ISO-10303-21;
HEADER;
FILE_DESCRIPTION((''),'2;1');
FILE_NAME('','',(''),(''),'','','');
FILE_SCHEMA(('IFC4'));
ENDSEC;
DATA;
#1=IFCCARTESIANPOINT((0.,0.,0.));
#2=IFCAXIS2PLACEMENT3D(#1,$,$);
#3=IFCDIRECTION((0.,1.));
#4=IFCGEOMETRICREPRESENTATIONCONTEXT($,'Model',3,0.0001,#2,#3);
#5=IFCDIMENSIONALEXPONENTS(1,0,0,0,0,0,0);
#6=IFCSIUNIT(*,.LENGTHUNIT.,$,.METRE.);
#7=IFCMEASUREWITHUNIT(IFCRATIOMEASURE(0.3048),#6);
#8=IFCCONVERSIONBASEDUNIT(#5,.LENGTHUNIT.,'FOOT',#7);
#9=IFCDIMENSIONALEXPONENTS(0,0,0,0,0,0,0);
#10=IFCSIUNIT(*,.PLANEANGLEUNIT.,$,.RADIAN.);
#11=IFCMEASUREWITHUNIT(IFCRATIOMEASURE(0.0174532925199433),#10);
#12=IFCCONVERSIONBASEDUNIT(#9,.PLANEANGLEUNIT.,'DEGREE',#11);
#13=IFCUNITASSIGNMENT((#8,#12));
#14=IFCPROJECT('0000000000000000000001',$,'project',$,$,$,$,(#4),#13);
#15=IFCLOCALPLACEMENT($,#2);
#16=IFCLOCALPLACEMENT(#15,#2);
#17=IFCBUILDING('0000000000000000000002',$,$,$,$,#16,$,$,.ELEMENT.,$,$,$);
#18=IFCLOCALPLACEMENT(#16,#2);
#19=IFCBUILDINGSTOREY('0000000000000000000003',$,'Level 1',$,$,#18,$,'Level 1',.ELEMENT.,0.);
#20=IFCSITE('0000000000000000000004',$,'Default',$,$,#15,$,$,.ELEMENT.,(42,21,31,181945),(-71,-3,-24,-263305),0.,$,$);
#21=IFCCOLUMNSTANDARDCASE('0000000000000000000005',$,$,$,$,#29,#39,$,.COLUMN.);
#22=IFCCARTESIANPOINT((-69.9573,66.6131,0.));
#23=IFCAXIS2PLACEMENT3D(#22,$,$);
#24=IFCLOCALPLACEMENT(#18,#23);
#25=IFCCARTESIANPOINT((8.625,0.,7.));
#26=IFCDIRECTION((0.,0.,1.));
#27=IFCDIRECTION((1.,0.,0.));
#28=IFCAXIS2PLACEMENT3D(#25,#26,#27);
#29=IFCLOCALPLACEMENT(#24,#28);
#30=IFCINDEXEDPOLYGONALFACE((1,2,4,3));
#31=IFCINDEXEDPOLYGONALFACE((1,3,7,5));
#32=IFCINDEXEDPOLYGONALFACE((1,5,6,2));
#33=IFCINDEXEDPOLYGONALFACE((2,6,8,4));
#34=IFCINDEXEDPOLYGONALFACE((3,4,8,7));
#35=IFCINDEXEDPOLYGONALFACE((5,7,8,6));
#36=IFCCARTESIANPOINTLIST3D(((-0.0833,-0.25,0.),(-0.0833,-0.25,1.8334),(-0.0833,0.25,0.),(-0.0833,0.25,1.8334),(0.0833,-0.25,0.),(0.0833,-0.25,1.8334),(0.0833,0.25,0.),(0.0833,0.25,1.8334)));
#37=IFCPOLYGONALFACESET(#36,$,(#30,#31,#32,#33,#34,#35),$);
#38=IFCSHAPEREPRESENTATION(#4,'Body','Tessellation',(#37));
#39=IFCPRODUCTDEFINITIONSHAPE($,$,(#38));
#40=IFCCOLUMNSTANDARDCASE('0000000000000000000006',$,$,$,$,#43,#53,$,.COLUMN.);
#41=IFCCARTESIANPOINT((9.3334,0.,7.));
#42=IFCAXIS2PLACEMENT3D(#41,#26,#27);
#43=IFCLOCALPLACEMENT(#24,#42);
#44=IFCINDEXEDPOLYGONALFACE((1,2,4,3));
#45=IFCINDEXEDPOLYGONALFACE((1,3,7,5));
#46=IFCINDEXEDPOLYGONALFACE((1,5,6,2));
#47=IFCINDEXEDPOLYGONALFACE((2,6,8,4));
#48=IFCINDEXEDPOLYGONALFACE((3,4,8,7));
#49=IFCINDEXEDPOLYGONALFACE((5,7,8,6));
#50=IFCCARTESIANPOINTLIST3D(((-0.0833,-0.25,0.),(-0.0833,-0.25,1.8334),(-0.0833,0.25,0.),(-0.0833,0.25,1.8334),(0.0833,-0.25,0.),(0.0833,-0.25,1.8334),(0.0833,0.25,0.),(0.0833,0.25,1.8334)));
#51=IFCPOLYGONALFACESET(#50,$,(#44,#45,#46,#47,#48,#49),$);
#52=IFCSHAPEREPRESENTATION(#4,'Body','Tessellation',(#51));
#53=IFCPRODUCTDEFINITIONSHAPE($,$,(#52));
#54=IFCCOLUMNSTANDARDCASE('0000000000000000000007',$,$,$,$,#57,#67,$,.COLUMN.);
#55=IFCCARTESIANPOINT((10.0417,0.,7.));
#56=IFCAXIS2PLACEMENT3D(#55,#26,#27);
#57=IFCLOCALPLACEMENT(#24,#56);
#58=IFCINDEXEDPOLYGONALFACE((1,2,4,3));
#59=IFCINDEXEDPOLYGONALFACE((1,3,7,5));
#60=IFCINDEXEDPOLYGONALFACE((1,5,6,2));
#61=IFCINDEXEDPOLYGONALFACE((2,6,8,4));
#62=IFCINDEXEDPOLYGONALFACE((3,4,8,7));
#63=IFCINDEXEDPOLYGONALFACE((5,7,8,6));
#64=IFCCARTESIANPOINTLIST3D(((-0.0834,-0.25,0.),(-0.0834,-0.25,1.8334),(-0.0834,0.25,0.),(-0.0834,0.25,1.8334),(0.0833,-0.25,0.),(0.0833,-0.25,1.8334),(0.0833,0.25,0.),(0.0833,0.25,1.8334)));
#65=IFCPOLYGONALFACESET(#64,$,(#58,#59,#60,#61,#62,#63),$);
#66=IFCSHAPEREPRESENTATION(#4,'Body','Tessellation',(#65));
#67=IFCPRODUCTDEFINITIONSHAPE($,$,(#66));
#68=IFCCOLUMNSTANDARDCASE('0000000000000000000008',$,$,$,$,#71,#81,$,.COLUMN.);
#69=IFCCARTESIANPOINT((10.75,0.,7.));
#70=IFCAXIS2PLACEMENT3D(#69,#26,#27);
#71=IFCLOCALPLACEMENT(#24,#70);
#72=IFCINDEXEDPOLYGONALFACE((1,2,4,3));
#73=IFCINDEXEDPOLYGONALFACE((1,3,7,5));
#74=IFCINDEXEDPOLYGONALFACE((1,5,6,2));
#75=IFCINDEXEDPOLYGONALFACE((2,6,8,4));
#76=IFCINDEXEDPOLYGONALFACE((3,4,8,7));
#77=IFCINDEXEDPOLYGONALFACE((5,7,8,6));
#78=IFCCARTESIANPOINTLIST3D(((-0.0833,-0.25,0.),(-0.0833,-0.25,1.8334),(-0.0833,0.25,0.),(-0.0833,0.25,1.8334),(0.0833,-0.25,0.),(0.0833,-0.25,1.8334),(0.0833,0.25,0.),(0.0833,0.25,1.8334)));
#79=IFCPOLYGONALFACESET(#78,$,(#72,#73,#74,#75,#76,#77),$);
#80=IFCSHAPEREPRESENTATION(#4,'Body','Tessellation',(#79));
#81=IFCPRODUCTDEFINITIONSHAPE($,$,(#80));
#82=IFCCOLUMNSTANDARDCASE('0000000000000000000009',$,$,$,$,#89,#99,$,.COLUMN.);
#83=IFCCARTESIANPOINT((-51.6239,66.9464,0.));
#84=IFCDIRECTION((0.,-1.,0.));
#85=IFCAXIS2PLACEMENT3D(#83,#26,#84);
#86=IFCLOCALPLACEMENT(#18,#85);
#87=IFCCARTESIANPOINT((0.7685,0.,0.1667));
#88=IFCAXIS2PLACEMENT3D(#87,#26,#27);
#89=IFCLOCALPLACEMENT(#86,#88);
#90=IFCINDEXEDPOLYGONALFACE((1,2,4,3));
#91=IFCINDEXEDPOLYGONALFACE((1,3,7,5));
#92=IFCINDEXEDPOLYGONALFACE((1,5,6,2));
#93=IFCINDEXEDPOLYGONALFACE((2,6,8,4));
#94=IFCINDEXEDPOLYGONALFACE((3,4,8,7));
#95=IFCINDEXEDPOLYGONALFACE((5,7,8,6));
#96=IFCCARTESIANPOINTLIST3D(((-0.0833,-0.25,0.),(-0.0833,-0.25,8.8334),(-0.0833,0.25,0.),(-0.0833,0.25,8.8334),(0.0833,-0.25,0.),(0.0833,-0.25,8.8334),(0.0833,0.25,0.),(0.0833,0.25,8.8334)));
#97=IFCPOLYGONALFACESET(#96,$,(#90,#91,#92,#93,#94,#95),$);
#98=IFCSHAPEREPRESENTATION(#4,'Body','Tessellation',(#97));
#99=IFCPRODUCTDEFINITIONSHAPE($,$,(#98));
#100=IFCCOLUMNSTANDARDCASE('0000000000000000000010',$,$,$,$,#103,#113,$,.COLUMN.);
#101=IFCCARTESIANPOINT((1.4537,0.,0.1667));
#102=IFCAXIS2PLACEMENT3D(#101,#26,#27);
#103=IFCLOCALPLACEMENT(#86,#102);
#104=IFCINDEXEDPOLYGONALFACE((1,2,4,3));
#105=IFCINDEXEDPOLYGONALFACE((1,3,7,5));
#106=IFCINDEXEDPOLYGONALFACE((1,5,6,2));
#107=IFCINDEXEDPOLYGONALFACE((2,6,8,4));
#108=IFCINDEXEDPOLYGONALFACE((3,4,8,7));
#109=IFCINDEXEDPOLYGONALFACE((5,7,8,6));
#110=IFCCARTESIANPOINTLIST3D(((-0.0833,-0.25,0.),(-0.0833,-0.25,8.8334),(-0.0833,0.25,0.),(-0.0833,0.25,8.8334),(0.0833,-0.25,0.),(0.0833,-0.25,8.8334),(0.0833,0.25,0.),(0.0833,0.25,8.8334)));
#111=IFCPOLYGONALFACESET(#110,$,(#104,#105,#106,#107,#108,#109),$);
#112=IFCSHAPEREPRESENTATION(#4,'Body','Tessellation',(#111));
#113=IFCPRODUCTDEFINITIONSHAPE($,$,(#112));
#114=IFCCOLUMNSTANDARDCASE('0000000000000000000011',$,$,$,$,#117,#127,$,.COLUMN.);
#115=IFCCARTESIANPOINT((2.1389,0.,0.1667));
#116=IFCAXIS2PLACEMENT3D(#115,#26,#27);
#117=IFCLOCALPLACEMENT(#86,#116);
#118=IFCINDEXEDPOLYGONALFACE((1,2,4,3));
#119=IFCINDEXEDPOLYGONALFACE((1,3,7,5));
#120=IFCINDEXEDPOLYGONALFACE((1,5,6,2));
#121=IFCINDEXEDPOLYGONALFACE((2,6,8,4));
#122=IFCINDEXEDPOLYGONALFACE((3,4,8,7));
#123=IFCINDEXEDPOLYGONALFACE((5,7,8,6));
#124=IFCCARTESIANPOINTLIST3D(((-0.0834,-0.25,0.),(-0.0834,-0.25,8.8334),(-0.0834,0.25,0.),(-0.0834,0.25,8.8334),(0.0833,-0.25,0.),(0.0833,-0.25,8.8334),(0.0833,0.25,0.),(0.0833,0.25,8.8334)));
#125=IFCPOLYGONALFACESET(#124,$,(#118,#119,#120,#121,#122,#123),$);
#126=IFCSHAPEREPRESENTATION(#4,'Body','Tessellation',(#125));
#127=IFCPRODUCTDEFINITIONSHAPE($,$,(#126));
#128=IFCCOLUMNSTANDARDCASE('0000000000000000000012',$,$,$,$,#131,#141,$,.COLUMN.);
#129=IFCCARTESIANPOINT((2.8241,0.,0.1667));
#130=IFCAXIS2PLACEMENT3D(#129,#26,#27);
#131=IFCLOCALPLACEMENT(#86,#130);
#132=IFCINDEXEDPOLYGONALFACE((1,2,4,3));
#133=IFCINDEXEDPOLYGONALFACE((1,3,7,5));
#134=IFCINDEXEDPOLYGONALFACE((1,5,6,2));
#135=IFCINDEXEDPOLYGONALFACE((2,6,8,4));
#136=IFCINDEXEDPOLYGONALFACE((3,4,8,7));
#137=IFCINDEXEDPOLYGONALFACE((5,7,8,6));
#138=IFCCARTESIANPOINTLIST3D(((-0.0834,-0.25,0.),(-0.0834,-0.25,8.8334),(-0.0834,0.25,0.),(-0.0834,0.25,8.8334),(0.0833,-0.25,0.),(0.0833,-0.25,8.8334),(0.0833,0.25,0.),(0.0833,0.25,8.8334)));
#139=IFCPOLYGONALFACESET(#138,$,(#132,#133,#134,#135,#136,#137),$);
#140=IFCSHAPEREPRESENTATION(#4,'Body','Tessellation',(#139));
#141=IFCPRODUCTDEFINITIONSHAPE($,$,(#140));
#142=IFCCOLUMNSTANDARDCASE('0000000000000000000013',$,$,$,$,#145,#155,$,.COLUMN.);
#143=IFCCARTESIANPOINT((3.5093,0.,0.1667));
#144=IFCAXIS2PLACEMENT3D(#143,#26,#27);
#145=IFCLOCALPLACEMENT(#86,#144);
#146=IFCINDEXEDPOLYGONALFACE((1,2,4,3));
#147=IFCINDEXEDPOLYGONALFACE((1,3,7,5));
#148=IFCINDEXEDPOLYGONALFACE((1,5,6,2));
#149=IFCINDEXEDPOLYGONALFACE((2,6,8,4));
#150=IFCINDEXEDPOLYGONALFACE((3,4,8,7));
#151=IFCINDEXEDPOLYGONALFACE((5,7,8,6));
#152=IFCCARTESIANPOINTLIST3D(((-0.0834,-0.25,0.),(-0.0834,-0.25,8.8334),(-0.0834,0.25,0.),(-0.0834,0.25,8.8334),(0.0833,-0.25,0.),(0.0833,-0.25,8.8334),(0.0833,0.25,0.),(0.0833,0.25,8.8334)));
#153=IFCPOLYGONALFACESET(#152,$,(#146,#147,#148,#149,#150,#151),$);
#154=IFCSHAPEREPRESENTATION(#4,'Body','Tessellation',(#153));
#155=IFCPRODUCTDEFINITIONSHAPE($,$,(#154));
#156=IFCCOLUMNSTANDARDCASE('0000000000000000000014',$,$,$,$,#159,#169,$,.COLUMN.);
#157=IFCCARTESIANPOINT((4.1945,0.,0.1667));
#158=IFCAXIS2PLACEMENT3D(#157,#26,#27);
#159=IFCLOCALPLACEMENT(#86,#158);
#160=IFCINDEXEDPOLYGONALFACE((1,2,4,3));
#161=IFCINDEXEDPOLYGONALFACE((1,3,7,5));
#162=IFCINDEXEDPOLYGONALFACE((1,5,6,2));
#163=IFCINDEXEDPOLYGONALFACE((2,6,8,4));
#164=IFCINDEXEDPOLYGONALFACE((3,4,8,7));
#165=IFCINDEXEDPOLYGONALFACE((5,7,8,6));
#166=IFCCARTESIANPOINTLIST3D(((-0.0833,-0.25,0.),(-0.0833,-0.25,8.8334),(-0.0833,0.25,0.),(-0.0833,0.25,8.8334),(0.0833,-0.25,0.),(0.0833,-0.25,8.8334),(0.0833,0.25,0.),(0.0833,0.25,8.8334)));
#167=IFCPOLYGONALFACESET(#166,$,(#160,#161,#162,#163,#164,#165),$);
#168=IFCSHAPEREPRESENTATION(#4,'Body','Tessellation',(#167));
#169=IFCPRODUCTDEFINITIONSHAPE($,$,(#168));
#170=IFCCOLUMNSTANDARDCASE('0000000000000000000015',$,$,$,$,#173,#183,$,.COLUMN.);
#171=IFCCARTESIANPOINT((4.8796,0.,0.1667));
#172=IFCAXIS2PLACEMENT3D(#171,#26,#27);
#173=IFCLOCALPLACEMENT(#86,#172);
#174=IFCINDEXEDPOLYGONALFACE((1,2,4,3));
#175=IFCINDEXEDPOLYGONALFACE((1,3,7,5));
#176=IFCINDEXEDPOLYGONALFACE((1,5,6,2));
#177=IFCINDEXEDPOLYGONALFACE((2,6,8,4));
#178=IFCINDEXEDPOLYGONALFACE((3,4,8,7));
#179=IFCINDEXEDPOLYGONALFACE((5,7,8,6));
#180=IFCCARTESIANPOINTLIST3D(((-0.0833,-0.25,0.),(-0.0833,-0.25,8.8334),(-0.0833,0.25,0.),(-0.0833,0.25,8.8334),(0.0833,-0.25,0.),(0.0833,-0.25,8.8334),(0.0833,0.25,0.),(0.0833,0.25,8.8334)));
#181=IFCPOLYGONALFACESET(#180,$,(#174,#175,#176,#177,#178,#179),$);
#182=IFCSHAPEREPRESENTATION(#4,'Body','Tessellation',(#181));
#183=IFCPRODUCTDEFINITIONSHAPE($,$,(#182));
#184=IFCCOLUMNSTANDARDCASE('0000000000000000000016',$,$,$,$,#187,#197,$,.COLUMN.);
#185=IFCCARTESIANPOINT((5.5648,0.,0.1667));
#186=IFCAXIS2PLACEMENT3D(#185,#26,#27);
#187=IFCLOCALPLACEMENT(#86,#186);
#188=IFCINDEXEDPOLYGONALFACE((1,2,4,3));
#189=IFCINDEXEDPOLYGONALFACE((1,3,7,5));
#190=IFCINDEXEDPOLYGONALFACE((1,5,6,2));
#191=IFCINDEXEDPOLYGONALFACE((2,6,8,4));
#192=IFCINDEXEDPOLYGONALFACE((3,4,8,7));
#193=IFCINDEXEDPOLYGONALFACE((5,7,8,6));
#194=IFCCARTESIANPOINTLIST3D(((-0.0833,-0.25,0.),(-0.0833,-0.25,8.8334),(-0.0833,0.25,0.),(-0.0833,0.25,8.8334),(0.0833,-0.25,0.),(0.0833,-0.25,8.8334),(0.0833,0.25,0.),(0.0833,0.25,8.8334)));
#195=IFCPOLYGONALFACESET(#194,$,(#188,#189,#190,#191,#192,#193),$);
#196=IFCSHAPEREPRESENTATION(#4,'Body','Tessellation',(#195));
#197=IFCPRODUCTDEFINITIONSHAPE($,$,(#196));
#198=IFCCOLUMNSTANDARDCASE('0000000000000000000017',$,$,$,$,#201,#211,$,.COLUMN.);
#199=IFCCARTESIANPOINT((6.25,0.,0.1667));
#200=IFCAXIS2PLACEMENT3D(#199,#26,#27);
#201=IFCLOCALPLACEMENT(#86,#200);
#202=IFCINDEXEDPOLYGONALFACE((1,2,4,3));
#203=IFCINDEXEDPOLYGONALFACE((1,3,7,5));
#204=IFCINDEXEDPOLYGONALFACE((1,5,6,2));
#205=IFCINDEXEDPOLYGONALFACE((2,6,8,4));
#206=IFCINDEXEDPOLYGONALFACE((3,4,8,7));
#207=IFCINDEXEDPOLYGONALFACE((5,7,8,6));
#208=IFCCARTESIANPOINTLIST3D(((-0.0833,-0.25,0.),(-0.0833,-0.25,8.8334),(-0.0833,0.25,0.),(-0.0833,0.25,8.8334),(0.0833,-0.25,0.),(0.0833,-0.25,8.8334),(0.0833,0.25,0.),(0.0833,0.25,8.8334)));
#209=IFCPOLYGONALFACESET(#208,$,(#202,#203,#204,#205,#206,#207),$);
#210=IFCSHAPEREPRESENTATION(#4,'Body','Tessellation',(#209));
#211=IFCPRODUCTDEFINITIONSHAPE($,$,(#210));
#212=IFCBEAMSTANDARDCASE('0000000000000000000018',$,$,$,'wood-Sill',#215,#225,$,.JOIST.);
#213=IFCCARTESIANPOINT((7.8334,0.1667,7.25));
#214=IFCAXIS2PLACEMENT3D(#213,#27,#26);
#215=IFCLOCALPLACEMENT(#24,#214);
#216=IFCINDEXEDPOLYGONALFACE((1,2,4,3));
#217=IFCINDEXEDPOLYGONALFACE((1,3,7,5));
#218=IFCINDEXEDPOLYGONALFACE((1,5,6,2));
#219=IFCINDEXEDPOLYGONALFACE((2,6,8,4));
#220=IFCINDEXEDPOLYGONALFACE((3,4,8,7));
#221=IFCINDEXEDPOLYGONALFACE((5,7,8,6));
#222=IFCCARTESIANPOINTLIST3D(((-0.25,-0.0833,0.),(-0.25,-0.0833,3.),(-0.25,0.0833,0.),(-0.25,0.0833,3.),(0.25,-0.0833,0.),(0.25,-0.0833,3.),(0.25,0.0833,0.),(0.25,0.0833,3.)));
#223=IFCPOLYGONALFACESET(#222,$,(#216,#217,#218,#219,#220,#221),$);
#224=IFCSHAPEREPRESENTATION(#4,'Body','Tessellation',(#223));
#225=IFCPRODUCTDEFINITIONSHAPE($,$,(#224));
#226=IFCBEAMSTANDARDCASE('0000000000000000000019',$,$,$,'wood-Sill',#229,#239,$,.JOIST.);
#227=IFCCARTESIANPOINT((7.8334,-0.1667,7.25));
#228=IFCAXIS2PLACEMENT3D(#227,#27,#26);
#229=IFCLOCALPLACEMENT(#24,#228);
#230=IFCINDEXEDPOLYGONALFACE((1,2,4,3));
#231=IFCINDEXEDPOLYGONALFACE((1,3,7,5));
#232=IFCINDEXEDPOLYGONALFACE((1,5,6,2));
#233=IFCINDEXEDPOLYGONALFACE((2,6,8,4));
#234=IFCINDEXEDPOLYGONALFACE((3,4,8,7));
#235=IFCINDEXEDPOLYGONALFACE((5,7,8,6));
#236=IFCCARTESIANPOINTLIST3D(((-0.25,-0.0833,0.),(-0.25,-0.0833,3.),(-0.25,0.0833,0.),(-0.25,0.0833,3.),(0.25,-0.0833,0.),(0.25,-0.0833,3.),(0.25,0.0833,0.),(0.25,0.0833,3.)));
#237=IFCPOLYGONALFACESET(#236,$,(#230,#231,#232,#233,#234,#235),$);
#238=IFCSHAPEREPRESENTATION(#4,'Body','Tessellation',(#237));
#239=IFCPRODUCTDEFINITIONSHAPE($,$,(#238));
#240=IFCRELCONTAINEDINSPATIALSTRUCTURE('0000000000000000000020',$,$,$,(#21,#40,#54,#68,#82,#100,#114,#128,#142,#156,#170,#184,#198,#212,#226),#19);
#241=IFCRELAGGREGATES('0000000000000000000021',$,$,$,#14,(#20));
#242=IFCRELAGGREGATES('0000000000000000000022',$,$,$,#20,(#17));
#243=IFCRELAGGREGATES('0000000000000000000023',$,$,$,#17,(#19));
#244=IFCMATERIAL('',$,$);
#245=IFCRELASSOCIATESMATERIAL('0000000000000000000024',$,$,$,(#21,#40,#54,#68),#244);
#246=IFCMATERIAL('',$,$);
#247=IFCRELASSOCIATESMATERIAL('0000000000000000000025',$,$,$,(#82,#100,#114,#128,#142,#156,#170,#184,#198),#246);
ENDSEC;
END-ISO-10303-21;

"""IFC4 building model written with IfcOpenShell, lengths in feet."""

from ifc_helpers import new_model, entity, si_unit, converted_unit, direction, frame, origin, origin_with_axes, place, context, project, spatial, rectangle, extrude, material, element, save


model = new_model("IFC4")

# Units and contexts
model_context = context("Model", 3, precision=0.0001, world=origin(), true_north=direction((0.0, 1.0)))
ifc_project = project(units=[converted_unit("LENGTHUNIT", "FOOT", entity("IfcRatioMeasure", 0.3048), si_unit("LENGTHUNIT", "METRE"), dimensions=[1, 0, 0, 0, 0, 0, 0]), converted_unit("PLANEANGLEUNIT", "DEGREE", entity("IfcRatioMeasure", 0.0174532925199433), si_unit("PLANEANGLEUNIT", "RADIAN"), dimensions=[0, 0, 0, 0, 0, 0, 0])], contexts=[model_context])

# Site, building, storey
site_placement = place(None, origin())
site = spatial("IfcSite", under=ifc_project, at=site_placement, Name="Default", CompositionType="ELEMENT", RefLatitude=(42, 21, 31, 181945), RefLongitude=(-71, -3, -24, -263305), RefElevation=0.0)
building_placement = place(site_placement, origin())
building = spatial("IfcBuilding", under=site, at=building_placement, CompositionType="ELEMENT")
storey_placement = place(building_placement, origin())
storey = spatial("IfcBuildingStorey", under=building, at=storey_placement, Name="Level 1", LongName="Level 1", CompositionType="ELEMENT", Elevation=0.0)

# Columns
ifc_material_1 = material(Name="")
placement_1 = place(storey_placement, frame((-69.9573, 66.6131, 0.0)))
ifc_material_2 = material(Name="")
for number, where, z_axis, x_axis in (
    (1, (8.625, 0.0, 7.0), (0.0, 0.0, 1.0), (1.0, 0.0, 0.0)),
    (2, (9.3334, 0.0, 7.0), (0.0, 0.0, 1.0), (1.0, 0.0, 0.0)),
    (3, (10.0417, 0.0, 7.0), (0.0, 0.0, 1.0), (1.0, 0.0, 0.0)),
    (4, (10.75, 0.0, 7.0), (0.0, 0.0, 1.0), (1.0, 0.0, 0.0)),
):
    element("IfcColumnStandardCase", number, at=place(placement_1, frame(where, z_axis=z_axis, x_axis=x_axis)), inside=storey, material=ifc_material_2, PredefinedType="COLUMN", context=model_context, shape_type="SweptSolid", body=[
        extrude(rectangle(XDim=0.1667, YDim=0.5), origin(), (0.0, 0.0, 1.0), 1.8334),
    ])
placement_2 = place(storey_placement, frame((-51.6239, 66.9464, 0.0), z_axis=(0.0, 0.0, 1.0), x_axis=(0.0, -1.0, 0.0)))
for number, where, z_axis, x_axis in (
    (5, (0.7685, 0.0, 0.1667), (0.0, 0.0, 1.0), (1.0, 0.0, 0.0)),
    (6, (1.4537, 0.0, 0.1667), (0.0, 0.0, 1.0), (1.0, 0.0, 0.0)),
    (7, (2.1389, 0.0, 0.1667), (0.0, 0.0, 1.0), (1.0, 0.0, 0.0)),
    (8, (2.8241, 0.0, 0.1667), (0.0, 0.0, 1.0), (1.0, 0.0, 0.0)),
    (9, (3.5093, 0.0, 0.1667), (0.0, 0.0, 1.0), (1.0, 0.0, 0.0)),
    (10, (4.1945, 0.0, 0.1667), (0.0, 0.0, 1.0), (1.0, 0.0, 0.0)),
    (11, (4.8796, 0.0, 0.1667), (0.0, 0.0, 1.0), (1.0, 0.0, 0.0)),
    (12, (5.5648, 0.0, 0.1667), (0.0, 0.0, 1.0), (1.0, 0.0, 0.0)),
    (13, (6.25, 0.0, 0.1667), (0.0, 0.0, 1.0), (1.0, 0.0, 0.0)),
):
    element("IfcColumnStandardCase", number, at=place(placement_2, frame(where, z_axis=z_axis, x_axis=x_axis)), inside=storey, material=ifc_material_1, PredefinedType="COLUMN", context=model_context, shape_type="SweptSolid", body=[
        extrude(rectangle(XDim=0.1667, YDim=0.5), origin(), (0.0, 0.0, 1.0), 8.8334),
    ])

# Beams
for number, where, z_axis, x_axis in (
    (14, (7.8334, 0.1667, 7.25), (1.0, 0.0, 0.0), (0.0, 0.0, 1.0)),
    (15, (7.8334, -0.1667, 7.25), (1.0, 0.0, 0.0), (0.0, 0.0, 1.0)),
):
    element("IfcBeamStandardCase", number, at=place(placement_1, frame(where, z_axis=z_axis, x_axis=x_axis)), inside=storey, ObjectType="wood-Sill", PredefinedType="JOIST", context=model_context, shape_type="SweptSolid", body=[
        extrude(rectangle(XDim=0.5, YDim=0.1667), origin_with_axes(), (0.0, 0.0, 1.0), 3.0),
    ])

save(model, "model.ifc")
